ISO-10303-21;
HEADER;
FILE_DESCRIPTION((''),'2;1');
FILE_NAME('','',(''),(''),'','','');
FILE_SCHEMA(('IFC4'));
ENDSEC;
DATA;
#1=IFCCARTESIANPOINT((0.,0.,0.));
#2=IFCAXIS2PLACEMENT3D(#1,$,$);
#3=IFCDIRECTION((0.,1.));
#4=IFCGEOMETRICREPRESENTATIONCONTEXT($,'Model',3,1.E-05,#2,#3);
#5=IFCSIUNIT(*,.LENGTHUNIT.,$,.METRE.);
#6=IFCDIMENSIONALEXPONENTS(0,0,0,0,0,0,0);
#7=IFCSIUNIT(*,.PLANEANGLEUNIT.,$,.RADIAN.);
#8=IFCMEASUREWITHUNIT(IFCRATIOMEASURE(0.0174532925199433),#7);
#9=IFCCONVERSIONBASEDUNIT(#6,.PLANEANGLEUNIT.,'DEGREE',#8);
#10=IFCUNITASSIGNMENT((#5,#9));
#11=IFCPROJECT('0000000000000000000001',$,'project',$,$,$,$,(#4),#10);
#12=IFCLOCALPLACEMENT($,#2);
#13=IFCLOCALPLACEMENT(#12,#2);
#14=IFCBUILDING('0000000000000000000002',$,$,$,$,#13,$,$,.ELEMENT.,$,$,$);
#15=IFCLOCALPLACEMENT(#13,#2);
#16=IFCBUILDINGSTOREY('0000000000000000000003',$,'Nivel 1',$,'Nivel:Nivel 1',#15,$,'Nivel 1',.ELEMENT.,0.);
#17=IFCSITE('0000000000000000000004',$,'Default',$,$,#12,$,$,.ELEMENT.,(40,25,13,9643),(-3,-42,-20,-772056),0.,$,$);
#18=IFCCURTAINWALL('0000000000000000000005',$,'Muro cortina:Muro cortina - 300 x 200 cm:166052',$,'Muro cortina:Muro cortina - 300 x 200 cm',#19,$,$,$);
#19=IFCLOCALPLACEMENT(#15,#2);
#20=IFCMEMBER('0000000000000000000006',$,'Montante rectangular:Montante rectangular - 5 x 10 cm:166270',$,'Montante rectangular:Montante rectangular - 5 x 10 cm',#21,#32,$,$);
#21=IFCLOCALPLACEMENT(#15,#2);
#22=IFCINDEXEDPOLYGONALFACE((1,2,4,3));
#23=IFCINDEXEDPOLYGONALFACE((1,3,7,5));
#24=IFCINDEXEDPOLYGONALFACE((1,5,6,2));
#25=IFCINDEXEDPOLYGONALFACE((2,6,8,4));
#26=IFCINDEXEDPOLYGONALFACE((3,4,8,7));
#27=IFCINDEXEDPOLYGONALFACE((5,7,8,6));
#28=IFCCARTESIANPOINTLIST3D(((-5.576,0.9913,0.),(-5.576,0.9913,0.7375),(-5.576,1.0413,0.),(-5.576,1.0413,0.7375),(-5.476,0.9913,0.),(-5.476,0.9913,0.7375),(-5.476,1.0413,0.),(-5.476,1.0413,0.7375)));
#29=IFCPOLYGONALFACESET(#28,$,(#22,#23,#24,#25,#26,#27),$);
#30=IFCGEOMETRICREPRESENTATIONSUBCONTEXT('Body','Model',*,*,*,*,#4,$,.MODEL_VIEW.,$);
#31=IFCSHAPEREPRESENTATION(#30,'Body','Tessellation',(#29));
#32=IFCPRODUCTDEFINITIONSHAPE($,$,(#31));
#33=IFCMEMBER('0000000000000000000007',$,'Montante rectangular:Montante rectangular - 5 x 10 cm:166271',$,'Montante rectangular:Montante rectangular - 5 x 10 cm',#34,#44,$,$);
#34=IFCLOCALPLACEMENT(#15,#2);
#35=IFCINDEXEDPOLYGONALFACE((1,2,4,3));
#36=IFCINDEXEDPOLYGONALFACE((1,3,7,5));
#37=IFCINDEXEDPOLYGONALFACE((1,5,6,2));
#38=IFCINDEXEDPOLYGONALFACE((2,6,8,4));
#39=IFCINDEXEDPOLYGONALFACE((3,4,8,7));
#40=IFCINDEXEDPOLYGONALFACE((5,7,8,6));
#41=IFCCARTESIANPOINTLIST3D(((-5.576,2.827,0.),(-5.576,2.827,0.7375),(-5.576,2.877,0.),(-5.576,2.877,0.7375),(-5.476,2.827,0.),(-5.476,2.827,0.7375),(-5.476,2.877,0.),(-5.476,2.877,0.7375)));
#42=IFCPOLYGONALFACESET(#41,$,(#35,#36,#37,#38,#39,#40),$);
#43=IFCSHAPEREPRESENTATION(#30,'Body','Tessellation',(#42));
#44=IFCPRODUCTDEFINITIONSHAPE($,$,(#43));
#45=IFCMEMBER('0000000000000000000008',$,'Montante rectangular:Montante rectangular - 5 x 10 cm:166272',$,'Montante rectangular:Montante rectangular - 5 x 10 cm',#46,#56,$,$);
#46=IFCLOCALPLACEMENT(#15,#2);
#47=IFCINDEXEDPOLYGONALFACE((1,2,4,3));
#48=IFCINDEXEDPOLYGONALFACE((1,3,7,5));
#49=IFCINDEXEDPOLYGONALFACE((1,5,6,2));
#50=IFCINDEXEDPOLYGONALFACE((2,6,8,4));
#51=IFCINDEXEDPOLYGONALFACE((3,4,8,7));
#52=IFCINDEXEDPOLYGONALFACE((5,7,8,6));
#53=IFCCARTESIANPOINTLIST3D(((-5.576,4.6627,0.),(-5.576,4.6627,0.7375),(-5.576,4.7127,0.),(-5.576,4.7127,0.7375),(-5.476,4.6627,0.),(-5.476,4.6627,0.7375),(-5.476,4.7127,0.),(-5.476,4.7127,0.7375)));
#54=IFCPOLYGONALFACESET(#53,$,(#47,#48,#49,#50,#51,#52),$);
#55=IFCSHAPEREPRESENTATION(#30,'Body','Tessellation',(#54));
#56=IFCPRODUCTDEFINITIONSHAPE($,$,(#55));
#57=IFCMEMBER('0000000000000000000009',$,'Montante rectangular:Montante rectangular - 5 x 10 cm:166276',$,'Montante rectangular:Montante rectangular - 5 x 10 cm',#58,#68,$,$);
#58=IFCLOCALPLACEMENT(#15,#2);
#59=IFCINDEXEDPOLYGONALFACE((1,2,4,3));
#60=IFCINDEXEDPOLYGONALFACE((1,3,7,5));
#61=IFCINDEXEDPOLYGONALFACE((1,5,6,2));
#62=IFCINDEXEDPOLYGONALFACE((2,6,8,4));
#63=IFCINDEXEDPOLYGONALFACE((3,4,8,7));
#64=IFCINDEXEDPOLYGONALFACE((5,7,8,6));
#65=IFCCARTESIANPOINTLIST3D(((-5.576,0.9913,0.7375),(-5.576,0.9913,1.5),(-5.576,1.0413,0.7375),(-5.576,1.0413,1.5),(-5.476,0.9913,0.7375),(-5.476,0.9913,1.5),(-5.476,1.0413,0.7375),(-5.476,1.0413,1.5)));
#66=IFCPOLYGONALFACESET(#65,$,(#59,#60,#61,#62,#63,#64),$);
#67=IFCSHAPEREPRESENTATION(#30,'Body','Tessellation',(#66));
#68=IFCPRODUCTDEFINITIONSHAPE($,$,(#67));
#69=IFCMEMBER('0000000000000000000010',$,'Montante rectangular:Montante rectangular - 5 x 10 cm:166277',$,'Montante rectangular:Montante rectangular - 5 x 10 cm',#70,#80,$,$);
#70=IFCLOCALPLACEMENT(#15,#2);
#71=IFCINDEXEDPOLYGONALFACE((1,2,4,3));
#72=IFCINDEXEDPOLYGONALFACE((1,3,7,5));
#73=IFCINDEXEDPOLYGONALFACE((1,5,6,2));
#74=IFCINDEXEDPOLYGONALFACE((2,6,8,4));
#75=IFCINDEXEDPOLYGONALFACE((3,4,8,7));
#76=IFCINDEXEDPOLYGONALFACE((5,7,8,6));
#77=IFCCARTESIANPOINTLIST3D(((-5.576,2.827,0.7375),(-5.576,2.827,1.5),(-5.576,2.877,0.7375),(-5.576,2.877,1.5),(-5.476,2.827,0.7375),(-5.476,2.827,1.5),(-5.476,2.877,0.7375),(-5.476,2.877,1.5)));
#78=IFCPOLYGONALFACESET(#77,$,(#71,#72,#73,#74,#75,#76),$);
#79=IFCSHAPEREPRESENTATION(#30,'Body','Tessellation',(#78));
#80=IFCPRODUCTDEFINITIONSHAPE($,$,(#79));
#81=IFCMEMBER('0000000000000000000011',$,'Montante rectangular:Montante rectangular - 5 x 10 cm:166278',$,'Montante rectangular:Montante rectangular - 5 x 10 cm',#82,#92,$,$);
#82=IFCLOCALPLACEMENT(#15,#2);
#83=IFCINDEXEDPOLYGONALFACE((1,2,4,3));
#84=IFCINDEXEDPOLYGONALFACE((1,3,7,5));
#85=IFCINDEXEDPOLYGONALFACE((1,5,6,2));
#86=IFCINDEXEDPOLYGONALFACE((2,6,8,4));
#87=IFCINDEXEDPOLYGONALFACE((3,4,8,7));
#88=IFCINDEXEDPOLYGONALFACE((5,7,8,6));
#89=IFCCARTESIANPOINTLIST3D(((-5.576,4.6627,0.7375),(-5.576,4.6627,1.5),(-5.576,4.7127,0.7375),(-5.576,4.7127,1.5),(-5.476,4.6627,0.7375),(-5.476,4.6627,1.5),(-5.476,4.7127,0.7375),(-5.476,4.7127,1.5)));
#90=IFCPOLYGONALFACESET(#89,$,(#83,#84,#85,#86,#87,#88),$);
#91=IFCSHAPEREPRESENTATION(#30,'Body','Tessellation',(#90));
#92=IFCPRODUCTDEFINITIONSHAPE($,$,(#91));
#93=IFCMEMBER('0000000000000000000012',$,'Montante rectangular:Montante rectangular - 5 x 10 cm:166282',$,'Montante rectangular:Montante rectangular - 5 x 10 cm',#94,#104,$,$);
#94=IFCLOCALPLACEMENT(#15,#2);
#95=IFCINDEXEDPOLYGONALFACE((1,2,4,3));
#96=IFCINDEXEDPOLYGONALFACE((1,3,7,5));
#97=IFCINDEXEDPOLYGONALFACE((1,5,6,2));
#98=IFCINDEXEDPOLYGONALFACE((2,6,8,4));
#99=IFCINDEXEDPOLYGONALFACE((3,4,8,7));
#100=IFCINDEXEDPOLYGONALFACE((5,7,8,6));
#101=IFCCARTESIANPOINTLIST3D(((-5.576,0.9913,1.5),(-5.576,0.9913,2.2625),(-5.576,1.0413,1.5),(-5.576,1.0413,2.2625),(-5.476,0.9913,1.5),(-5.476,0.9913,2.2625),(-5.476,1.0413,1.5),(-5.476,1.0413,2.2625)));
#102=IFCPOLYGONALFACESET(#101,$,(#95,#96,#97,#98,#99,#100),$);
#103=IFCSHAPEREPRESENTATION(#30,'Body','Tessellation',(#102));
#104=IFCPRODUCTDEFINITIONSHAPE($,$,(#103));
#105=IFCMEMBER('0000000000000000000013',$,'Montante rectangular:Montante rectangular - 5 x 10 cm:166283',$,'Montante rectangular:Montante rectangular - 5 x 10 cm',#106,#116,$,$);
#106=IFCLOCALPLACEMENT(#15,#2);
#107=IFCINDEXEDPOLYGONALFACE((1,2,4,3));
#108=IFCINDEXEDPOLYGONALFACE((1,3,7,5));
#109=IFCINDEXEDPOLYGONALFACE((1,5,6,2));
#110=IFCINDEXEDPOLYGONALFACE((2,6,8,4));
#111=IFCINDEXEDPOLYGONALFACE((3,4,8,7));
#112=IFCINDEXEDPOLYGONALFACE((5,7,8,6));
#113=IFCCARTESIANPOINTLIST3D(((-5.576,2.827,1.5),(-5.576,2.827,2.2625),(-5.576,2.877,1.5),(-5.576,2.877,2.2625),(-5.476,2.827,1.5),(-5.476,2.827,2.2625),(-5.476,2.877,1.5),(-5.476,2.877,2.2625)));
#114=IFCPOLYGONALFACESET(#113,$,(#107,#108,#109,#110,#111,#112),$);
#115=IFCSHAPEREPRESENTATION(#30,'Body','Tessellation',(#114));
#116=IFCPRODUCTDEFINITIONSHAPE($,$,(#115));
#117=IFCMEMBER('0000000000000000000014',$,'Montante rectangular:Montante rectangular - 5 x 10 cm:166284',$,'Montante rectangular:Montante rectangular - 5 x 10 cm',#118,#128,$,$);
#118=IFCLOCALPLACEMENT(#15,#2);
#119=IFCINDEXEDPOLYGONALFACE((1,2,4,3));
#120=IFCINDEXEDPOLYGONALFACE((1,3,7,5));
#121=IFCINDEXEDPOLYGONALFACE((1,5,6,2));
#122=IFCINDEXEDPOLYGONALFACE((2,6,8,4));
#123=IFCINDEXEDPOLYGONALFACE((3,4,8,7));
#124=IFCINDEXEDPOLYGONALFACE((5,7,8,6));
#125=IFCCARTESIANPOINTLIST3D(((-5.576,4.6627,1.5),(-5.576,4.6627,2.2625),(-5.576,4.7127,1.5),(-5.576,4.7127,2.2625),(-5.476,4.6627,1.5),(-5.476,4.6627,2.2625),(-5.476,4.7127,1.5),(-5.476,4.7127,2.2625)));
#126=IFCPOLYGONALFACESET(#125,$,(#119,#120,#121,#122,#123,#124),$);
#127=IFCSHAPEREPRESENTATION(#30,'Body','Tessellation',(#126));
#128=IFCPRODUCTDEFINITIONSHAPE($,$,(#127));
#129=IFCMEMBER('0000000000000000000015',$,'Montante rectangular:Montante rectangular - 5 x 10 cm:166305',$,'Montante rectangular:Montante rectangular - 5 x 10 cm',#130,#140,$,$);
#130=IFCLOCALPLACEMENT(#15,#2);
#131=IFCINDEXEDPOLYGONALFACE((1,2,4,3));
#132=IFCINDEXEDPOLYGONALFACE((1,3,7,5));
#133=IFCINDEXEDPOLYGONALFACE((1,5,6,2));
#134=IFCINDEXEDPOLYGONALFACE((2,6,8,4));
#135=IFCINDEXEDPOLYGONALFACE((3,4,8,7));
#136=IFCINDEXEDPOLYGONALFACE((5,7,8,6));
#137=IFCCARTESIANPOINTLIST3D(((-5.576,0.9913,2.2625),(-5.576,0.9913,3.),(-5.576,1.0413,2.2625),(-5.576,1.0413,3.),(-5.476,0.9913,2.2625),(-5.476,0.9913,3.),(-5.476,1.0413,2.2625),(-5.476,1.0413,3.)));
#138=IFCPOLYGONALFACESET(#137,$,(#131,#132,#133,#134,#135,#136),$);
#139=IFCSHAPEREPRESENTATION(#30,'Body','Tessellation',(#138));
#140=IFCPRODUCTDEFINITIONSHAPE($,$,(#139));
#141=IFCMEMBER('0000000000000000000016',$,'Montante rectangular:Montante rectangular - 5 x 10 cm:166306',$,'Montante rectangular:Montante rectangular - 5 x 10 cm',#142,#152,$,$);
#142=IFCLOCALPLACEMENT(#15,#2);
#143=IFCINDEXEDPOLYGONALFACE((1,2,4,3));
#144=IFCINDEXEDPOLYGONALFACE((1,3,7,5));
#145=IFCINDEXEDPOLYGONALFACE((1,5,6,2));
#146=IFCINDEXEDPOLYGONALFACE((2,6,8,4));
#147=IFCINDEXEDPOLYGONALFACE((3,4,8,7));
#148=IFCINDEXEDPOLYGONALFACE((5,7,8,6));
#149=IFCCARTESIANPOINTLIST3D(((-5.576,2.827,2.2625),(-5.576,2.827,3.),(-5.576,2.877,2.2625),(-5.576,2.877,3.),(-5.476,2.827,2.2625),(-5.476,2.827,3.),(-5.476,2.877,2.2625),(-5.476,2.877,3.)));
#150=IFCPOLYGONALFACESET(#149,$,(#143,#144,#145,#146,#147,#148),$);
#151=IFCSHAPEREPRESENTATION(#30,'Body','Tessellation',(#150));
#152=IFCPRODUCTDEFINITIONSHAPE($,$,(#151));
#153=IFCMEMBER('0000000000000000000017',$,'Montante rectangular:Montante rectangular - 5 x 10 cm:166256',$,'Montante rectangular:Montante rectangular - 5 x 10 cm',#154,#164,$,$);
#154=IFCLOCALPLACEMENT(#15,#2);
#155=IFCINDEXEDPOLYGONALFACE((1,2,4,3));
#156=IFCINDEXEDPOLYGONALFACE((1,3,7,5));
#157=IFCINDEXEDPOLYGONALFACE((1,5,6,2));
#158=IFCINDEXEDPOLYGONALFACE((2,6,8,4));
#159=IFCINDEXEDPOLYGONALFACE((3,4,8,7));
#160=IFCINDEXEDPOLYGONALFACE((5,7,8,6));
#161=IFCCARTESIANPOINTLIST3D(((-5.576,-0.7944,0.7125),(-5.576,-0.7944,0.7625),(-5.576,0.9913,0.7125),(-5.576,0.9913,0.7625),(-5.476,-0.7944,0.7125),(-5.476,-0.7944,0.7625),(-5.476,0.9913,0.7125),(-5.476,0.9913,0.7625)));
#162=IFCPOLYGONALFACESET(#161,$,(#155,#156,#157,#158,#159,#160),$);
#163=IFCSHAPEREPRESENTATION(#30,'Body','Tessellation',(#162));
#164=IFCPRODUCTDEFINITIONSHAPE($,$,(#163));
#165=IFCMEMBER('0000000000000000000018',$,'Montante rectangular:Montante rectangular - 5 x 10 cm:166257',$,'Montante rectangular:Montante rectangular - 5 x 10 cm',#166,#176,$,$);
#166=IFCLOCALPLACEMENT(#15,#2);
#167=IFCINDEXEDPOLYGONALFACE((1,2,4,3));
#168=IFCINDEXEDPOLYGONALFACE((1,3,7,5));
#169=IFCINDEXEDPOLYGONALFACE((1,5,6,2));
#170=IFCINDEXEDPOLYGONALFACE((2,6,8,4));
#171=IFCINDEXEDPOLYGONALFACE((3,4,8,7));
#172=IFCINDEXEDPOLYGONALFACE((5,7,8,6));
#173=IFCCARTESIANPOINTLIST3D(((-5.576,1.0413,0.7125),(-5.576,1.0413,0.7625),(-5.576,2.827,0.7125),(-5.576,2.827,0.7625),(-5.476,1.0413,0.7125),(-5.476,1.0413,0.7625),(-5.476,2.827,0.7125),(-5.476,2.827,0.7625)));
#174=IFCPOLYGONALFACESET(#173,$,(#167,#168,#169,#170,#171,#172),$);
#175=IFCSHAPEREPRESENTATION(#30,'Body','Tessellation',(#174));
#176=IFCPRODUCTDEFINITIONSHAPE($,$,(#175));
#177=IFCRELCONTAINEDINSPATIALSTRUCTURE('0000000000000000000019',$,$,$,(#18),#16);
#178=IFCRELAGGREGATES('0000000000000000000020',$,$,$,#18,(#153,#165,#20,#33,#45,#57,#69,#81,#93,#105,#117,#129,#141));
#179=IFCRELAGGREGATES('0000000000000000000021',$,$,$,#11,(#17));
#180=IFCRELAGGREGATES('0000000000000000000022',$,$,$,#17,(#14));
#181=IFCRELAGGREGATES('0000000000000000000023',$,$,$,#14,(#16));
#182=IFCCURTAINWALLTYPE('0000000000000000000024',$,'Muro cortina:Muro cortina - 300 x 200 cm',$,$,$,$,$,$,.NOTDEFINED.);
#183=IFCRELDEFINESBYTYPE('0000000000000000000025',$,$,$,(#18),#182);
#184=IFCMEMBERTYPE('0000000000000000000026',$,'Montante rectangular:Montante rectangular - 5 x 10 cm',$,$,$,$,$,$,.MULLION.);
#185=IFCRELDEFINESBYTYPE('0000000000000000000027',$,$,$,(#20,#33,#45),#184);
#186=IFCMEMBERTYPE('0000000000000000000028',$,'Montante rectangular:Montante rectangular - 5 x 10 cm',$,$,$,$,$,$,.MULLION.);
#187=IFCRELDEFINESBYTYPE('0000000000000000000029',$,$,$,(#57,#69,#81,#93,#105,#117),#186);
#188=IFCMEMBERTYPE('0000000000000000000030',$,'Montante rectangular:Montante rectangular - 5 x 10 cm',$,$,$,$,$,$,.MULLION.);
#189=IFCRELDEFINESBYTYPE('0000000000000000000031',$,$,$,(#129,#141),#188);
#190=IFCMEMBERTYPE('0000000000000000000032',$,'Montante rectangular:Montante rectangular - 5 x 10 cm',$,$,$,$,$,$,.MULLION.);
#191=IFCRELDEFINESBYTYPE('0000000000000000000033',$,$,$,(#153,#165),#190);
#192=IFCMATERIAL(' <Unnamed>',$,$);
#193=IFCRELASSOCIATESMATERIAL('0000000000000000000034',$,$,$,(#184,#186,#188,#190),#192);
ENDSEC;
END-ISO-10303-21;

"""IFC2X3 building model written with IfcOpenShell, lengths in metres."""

from ifc_helpers import new_model, entity, si_unit, converted_unit, direction, frame, origin, origin_2d_with_axis, place, context, subcontext, project, spatial, rectangle, extrude, source, transform, mapped, material, type_object, type_shapes, element, aggregate, save


model = new_model("IFC2X3")

# Units and contexts
model_context = context("Model", 3, precision=1e-05, world=origin(), true_north=direction((0.0, 1.0)))
body_context = subcontext(model_context, "Body", "Model", "MODEL_VIEW")
ifc_project = project(units=[si_unit("LENGTHUNIT", "METRE"), converted_unit("PLANEANGLEUNIT", "DEGREE", entity("IfcRatioMeasure", 0.0174532925199433), si_unit("PLANEANGLEUNIT", "RADIAN"), dimensions=[0, 0, 0, 0, 0, 0, 0])], contexts=[model_context])

# Site, building, storey
site_placement = place(None, origin())
site = spatial("IfcSite", under=ifc_project, at=site_placement, Name="Default", CompositionType="ELEMENT", RefLatitude=(40, 25, 13, 9643), RefLongitude=(-3, -42, -20, -772056), RefElevation=0.0)
building_placement = place(site_placement, origin())
building = spatial("IfcBuilding", under=site, at=building_placement, CompositionType="ELEMENT")
storey_placement = place(building_placement, origin())
storey = spatial("IfcBuildingStorey", under=building, at=storey_placement, Name="Nivel 1", ObjectType="Nivel:Nivel 1", LongName="Nivel 1", CompositionType="ELEMENT", Elevation=0.0)

# Curtain wall, members
curtain_wall_type = type_object("IfcCurtainWallType", Name="Muro cortina:Muro cortina - 300 x 200 cm", PredefinedType="NOTDEFINED")
curtain_wall_placement = place(storey_placement, origin())
curtain_wall = element("IfcCurtainWall", 1, at=curtain_wall_placement, inside=storey, type_object=curtain_wall_type, Name="Muro cortina:Muro cortina - 300 x 200 cm:166052", ObjectType="Muro cortina:Muro cortina - 300 x 200 cm")
ifc_material_1 = material(Name=" <Unnamed>")
member_type_1 = type_object("IfcMemberType", Name="Montante rectangular:Montante rectangular - 5 x 10 cm", PredefinedType="MULLION", material=ifc_material_1)
shared_shape_1 = source(origin(), body_context, "Body", "SweptSolid", [
    extrude(rectangle(XDim=0.1, YDim=0.05, at=origin_2d_with_axis()), frame((0.0, 0.0, -0.7375), z_axis=(0.0, 0.0, 1.0), x_axis=(0.0, -1.0, 0.0)), (0.0, 0.0, 1.0), 0.7375),
])
type_shapes(member_type_1, [shared_shape_1])
member_1_placement = place(storey_placement, frame((-5.526, 1.0163, 0.0), z_axis=(0.0, 0.0, -1.0), x_axis=(0.0, 1.0, 0.0)))
member_1 = element("IfcMember", 2, at=member_1_placement, type_object=member_type_1, Name="Montante rectangular:Montante rectangular - 5 x 10 cm:166270", ObjectType="Montante rectangular:Montante rectangular - 5 x 10 cm", context=body_context, shape_type="MappedRepresentation", body=[
    mapped(shared_shape_1, transform((0.0, 0.0, 0.0), scale=1.0)),
])
member_2_placement = place(storey_placement, frame((-5.526, 2.852, 0.0), z_axis=(0.0, 0.0, -1.0), x_axis=(0.0, 1.0, 0.0)))
member_2 = element("IfcMember", 3, at=member_2_placement, type_object=member_type_1, Name="Montante rectangular:Montante rectangular - 5 x 10 cm:166271", ObjectType="Montante rectangular:Montante rectangular - 5 x 10 cm", context=body_context, shape_type="MappedRepresentation", body=[
    mapped(shared_shape_1, transform((0.0, 0.0, 0.0), scale=1.0)),
])
member_3_placement = place(storey_placement, frame((-5.526, 4.6877, 0.0), z_axis=(0.0, 0.0, -1.0), x_axis=(0.0, 1.0, 0.0)))
member_3 = element("IfcMember", 4, at=member_3_placement, type_object=member_type_1, Name="Montante rectangular:Montante rectangular - 5 x 10 cm:166272", ObjectType="Montante rectangular:Montante rectangular - 5 x 10 cm", context=body_context, shape_type="MappedRepresentation", body=[
    mapped(shared_shape_1, transform((0.0, 0.0, 0.0), scale=1.0)),
])
member_type_2 = type_object("IfcMemberType", Name="Montante rectangular:Montante rectangular - 5 x 10 cm", PredefinedType="MULLION", material=ifc_material_1)
shared_shape_2 = source(origin(), body_context, "Body", "SweptSolid", [
    extrude(rectangle(XDim=0.1, YDim=0.05, at=origin_2d_with_axis()), frame((0.0, 0.0, -0.7625), z_axis=(0.0, 0.0, 1.0), x_axis=(0.0, -1.0, 0.0)), (0.0, 0.0, 1.0), 0.7625),
])
type_shapes(member_type_2, [shared_shape_2])
member_4_placement = place(storey_placement, frame((-5.526, 1.0163, 0.7375), z_axis=(0.0, 0.0, -1.0), x_axis=(0.0, 1.0, 0.0)))
member_4 = element("IfcMember", 5, at=member_4_placement, type_object=member_type_2, Name="Montante rectangular:Montante rectangular - 5 x 10 cm:166276", ObjectType="Montante rectangular:Montante rectangular - 5 x 10 cm", context=body_context, shape_type="MappedRepresentation", body=[
    mapped(shared_shape_2, transform((0.0, 0.0, 0.0), scale=1.0)),
])
member_5_placement = place(storey_placement, frame((-5.526, 2.852, 0.7375), z_axis=(0.0, 0.0, -1.0), x_axis=(0.0, 1.0, 0.0)))
member_5 = element("IfcMember", 6, at=member_5_placement, type_object=member_type_2, Name="Montante rectangular:Montante rectangular - 5 x 10 cm:166277", ObjectType="Montante rectangular:Montante rectangular - 5 x 10 cm", context=body_context, shape_type="MappedRepresentation", body=[
    mapped(shared_shape_2, transform((0.0, 0.0, 0.0), scale=1.0)),
])
member_6_placement = place(storey_placement, frame((-5.526, 4.6877, 0.7375), z_axis=(0.0, 0.0, -1.0), x_axis=(0.0, 1.0, 0.0)))
member_6 = element("IfcMember", 7, at=member_6_placement, type_object=member_type_2, Name="Montante rectangular:Montante rectangular - 5 x 10 cm:166278", ObjectType="Montante rectangular:Montante rectangular - 5 x 10 cm", context=body_context, shape_type="MappedRepresentation", body=[
    mapped(shared_shape_2, transform((0.0, 0.0, 0.0), scale=1.0)),
])
member_7_placement = place(storey_placement, frame((-5.526, 1.0163, 1.5), z_axis=(0.0, 0.0, -1.0), x_axis=(0.0, 1.0, 0.0)))
member_7 = element("IfcMember", 8, at=member_7_placement, type_object=member_type_2, Name="Montante rectangular:Montante rectangular - 5 x 10 cm:166282", ObjectType="Montante rectangular:Montante rectangular - 5 x 10 cm", context=body_context, shape_type="MappedRepresentation", body=[
    mapped(shared_shape_2, transform((0.0, 0.0, 0.0), scale=1.0)),
])
member_8_placement = place(storey_placement, frame((-5.526, 2.852, 1.5), z_axis=(0.0, 0.0, -1.0), x_axis=(0.0, 1.0, 0.0)))
member_8 = element("IfcMember", 9, at=member_8_placement, type_object=member_type_2, Name="Montante rectangular:Montante rectangular - 5 x 10 cm:166283", ObjectType="Montante rectangular:Montante rectangular - 5 x 10 cm", context=body_context, shape_type="MappedRepresentation", body=[
    mapped(shared_shape_2, transform((0.0, 0.0, 0.0), scale=1.0)),
])
member_9_placement = place(storey_placement, frame((-5.526, 4.6877, 1.5), z_axis=(0.0, 0.0, -1.0), x_axis=(0.0, 1.0, 0.0)))
member_9 = element("IfcMember", 10, at=member_9_placement, type_object=member_type_2, Name="Montante rectangular:Montante rectangular - 5 x 10 cm:166284", ObjectType="Montante rectangular:Montante rectangular - 5 x 10 cm", context=body_context, shape_type="MappedRepresentation", body=[
    mapped(shared_shape_2, transform((0.0, 0.0, 0.0), scale=1.0)),
])
member_type_3 = type_object("IfcMemberType", Name="Montante rectangular:Montante rectangular - 5 x 10 cm", PredefinedType="MULLION", material=ifc_material_1)
shared_shape_3 = source(origin(), body_context, "Body", "SweptSolid", [
    extrude(rectangle(XDim=0.1, YDim=0.05, at=origin_2d_with_axis()), frame((0.0, 0.0, -0.7375), z_axis=(0.0, 0.0, 1.0), x_axis=(0.0, -1.0, 0.0)), (0.0, 0.0, 1.0), 0.7375),
])
type_shapes(member_type_3, [shared_shape_3])
member_10_placement = place(storey_placement, frame((-5.526, 1.0163, 2.2625), z_axis=(0.0, 0.0, -1.0), x_axis=(0.0, 1.0, 0.0)))
member_10 = element("IfcMember", 11, at=member_10_placement, type_object=member_type_3, Name="Montante rectangular:Montante rectangular - 5 x 10 cm:166305", ObjectType="Montante rectangular:Montante rectangular - 5 x 10 cm", context=body_context, shape_type="MappedRepresentation", body=[
    mapped(shared_shape_3, transform((0.0, 0.0, 0.0), scale=1.0)),
])
member_11_placement = place(storey_placement, frame((-5.526, 2.852, 2.2625), z_axis=(0.0, 0.0, -1.0), x_axis=(0.0, 1.0, 0.0)))
member_11 = element("IfcMember", 12, at=member_11_placement, type_object=member_type_3, Name="Montante rectangular:Montante rectangular - 5 x 10 cm:166306", ObjectType="Montante rectangular:Montante rectangular - 5 x 10 cm", context=body_context, shape_type="MappedRepresentation", body=[
    mapped(shared_shape_3, transform((0.0, 0.0, 0.0), scale=1.0)),
])
member_type_4 = type_object("IfcMemberType", Name="Montante rectangular:Montante rectangular - 5 x 10 cm", PredefinedType="MULLION", material=ifc_material_1)
shared_shape_4 = source(origin(), body_context, "Body", "SweptSolid", [
    extrude(rectangle(XDim=0.1, YDim=0.05, at=origin_2d_with_axis()), frame((0.0, 0.0, -1.7857), z_axis=(0.0, 0.0, 1.0), x_axis=(0.0, -1.0, 0.0)), (0.0, 0.0, 1.0), 1.7857),
])
type_shapes(member_type_4, [shared_shape_4])
member_12_placement = place(storey_placement, frame((-5.526, 0.9913, 0.7375), z_axis=(0.0, 1.0, 0.0), x_axis=(0.0, 0.0, 1.0)))
member_12 = element("IfcMember", 13, at=member_12_placement, type_object=member_type_4, Name="Montante rectangular:Montante rectangular - 5 x 10 cm:166256", ObjectType="Montante rectangular:Montante rectangular - 5 x 10 cm", context=body_context, shape_type="MappedRepresentation", body=[
    mapped(shared_shape_4, transform((0.0, 0.0, 0.0), scale=1.0)),
])
member_13_placement = place(storey_placement, frame((-5.526, 2.827, 0.7375), z_axis=(0.0, 1.0, 0.0), x_axis=(0.0, 0.0, 1.0)))
member_13 = element("IfcMember", 14, at=member_13_placement, type_object=member_type_4, Name="Montante rectangular:Montante rectangular - 5 x 10 cm:166257", ObjectType="Montante rectangular:Montante rectangular - 5 x 10 cm", context=body_context, shape_type="MappedRepresentation", body=[
    mapped(shared_shape_4, transform((0.0, 0.0, 0.0), scale=1.0)),
])
aggregate(curtain_wall, [member_12, member_13, member_1, member_2, member_3, member_4, member_5, member_6, member_7, member_8, member_9, member_10, member_11])

save(model, "model.ifc")
